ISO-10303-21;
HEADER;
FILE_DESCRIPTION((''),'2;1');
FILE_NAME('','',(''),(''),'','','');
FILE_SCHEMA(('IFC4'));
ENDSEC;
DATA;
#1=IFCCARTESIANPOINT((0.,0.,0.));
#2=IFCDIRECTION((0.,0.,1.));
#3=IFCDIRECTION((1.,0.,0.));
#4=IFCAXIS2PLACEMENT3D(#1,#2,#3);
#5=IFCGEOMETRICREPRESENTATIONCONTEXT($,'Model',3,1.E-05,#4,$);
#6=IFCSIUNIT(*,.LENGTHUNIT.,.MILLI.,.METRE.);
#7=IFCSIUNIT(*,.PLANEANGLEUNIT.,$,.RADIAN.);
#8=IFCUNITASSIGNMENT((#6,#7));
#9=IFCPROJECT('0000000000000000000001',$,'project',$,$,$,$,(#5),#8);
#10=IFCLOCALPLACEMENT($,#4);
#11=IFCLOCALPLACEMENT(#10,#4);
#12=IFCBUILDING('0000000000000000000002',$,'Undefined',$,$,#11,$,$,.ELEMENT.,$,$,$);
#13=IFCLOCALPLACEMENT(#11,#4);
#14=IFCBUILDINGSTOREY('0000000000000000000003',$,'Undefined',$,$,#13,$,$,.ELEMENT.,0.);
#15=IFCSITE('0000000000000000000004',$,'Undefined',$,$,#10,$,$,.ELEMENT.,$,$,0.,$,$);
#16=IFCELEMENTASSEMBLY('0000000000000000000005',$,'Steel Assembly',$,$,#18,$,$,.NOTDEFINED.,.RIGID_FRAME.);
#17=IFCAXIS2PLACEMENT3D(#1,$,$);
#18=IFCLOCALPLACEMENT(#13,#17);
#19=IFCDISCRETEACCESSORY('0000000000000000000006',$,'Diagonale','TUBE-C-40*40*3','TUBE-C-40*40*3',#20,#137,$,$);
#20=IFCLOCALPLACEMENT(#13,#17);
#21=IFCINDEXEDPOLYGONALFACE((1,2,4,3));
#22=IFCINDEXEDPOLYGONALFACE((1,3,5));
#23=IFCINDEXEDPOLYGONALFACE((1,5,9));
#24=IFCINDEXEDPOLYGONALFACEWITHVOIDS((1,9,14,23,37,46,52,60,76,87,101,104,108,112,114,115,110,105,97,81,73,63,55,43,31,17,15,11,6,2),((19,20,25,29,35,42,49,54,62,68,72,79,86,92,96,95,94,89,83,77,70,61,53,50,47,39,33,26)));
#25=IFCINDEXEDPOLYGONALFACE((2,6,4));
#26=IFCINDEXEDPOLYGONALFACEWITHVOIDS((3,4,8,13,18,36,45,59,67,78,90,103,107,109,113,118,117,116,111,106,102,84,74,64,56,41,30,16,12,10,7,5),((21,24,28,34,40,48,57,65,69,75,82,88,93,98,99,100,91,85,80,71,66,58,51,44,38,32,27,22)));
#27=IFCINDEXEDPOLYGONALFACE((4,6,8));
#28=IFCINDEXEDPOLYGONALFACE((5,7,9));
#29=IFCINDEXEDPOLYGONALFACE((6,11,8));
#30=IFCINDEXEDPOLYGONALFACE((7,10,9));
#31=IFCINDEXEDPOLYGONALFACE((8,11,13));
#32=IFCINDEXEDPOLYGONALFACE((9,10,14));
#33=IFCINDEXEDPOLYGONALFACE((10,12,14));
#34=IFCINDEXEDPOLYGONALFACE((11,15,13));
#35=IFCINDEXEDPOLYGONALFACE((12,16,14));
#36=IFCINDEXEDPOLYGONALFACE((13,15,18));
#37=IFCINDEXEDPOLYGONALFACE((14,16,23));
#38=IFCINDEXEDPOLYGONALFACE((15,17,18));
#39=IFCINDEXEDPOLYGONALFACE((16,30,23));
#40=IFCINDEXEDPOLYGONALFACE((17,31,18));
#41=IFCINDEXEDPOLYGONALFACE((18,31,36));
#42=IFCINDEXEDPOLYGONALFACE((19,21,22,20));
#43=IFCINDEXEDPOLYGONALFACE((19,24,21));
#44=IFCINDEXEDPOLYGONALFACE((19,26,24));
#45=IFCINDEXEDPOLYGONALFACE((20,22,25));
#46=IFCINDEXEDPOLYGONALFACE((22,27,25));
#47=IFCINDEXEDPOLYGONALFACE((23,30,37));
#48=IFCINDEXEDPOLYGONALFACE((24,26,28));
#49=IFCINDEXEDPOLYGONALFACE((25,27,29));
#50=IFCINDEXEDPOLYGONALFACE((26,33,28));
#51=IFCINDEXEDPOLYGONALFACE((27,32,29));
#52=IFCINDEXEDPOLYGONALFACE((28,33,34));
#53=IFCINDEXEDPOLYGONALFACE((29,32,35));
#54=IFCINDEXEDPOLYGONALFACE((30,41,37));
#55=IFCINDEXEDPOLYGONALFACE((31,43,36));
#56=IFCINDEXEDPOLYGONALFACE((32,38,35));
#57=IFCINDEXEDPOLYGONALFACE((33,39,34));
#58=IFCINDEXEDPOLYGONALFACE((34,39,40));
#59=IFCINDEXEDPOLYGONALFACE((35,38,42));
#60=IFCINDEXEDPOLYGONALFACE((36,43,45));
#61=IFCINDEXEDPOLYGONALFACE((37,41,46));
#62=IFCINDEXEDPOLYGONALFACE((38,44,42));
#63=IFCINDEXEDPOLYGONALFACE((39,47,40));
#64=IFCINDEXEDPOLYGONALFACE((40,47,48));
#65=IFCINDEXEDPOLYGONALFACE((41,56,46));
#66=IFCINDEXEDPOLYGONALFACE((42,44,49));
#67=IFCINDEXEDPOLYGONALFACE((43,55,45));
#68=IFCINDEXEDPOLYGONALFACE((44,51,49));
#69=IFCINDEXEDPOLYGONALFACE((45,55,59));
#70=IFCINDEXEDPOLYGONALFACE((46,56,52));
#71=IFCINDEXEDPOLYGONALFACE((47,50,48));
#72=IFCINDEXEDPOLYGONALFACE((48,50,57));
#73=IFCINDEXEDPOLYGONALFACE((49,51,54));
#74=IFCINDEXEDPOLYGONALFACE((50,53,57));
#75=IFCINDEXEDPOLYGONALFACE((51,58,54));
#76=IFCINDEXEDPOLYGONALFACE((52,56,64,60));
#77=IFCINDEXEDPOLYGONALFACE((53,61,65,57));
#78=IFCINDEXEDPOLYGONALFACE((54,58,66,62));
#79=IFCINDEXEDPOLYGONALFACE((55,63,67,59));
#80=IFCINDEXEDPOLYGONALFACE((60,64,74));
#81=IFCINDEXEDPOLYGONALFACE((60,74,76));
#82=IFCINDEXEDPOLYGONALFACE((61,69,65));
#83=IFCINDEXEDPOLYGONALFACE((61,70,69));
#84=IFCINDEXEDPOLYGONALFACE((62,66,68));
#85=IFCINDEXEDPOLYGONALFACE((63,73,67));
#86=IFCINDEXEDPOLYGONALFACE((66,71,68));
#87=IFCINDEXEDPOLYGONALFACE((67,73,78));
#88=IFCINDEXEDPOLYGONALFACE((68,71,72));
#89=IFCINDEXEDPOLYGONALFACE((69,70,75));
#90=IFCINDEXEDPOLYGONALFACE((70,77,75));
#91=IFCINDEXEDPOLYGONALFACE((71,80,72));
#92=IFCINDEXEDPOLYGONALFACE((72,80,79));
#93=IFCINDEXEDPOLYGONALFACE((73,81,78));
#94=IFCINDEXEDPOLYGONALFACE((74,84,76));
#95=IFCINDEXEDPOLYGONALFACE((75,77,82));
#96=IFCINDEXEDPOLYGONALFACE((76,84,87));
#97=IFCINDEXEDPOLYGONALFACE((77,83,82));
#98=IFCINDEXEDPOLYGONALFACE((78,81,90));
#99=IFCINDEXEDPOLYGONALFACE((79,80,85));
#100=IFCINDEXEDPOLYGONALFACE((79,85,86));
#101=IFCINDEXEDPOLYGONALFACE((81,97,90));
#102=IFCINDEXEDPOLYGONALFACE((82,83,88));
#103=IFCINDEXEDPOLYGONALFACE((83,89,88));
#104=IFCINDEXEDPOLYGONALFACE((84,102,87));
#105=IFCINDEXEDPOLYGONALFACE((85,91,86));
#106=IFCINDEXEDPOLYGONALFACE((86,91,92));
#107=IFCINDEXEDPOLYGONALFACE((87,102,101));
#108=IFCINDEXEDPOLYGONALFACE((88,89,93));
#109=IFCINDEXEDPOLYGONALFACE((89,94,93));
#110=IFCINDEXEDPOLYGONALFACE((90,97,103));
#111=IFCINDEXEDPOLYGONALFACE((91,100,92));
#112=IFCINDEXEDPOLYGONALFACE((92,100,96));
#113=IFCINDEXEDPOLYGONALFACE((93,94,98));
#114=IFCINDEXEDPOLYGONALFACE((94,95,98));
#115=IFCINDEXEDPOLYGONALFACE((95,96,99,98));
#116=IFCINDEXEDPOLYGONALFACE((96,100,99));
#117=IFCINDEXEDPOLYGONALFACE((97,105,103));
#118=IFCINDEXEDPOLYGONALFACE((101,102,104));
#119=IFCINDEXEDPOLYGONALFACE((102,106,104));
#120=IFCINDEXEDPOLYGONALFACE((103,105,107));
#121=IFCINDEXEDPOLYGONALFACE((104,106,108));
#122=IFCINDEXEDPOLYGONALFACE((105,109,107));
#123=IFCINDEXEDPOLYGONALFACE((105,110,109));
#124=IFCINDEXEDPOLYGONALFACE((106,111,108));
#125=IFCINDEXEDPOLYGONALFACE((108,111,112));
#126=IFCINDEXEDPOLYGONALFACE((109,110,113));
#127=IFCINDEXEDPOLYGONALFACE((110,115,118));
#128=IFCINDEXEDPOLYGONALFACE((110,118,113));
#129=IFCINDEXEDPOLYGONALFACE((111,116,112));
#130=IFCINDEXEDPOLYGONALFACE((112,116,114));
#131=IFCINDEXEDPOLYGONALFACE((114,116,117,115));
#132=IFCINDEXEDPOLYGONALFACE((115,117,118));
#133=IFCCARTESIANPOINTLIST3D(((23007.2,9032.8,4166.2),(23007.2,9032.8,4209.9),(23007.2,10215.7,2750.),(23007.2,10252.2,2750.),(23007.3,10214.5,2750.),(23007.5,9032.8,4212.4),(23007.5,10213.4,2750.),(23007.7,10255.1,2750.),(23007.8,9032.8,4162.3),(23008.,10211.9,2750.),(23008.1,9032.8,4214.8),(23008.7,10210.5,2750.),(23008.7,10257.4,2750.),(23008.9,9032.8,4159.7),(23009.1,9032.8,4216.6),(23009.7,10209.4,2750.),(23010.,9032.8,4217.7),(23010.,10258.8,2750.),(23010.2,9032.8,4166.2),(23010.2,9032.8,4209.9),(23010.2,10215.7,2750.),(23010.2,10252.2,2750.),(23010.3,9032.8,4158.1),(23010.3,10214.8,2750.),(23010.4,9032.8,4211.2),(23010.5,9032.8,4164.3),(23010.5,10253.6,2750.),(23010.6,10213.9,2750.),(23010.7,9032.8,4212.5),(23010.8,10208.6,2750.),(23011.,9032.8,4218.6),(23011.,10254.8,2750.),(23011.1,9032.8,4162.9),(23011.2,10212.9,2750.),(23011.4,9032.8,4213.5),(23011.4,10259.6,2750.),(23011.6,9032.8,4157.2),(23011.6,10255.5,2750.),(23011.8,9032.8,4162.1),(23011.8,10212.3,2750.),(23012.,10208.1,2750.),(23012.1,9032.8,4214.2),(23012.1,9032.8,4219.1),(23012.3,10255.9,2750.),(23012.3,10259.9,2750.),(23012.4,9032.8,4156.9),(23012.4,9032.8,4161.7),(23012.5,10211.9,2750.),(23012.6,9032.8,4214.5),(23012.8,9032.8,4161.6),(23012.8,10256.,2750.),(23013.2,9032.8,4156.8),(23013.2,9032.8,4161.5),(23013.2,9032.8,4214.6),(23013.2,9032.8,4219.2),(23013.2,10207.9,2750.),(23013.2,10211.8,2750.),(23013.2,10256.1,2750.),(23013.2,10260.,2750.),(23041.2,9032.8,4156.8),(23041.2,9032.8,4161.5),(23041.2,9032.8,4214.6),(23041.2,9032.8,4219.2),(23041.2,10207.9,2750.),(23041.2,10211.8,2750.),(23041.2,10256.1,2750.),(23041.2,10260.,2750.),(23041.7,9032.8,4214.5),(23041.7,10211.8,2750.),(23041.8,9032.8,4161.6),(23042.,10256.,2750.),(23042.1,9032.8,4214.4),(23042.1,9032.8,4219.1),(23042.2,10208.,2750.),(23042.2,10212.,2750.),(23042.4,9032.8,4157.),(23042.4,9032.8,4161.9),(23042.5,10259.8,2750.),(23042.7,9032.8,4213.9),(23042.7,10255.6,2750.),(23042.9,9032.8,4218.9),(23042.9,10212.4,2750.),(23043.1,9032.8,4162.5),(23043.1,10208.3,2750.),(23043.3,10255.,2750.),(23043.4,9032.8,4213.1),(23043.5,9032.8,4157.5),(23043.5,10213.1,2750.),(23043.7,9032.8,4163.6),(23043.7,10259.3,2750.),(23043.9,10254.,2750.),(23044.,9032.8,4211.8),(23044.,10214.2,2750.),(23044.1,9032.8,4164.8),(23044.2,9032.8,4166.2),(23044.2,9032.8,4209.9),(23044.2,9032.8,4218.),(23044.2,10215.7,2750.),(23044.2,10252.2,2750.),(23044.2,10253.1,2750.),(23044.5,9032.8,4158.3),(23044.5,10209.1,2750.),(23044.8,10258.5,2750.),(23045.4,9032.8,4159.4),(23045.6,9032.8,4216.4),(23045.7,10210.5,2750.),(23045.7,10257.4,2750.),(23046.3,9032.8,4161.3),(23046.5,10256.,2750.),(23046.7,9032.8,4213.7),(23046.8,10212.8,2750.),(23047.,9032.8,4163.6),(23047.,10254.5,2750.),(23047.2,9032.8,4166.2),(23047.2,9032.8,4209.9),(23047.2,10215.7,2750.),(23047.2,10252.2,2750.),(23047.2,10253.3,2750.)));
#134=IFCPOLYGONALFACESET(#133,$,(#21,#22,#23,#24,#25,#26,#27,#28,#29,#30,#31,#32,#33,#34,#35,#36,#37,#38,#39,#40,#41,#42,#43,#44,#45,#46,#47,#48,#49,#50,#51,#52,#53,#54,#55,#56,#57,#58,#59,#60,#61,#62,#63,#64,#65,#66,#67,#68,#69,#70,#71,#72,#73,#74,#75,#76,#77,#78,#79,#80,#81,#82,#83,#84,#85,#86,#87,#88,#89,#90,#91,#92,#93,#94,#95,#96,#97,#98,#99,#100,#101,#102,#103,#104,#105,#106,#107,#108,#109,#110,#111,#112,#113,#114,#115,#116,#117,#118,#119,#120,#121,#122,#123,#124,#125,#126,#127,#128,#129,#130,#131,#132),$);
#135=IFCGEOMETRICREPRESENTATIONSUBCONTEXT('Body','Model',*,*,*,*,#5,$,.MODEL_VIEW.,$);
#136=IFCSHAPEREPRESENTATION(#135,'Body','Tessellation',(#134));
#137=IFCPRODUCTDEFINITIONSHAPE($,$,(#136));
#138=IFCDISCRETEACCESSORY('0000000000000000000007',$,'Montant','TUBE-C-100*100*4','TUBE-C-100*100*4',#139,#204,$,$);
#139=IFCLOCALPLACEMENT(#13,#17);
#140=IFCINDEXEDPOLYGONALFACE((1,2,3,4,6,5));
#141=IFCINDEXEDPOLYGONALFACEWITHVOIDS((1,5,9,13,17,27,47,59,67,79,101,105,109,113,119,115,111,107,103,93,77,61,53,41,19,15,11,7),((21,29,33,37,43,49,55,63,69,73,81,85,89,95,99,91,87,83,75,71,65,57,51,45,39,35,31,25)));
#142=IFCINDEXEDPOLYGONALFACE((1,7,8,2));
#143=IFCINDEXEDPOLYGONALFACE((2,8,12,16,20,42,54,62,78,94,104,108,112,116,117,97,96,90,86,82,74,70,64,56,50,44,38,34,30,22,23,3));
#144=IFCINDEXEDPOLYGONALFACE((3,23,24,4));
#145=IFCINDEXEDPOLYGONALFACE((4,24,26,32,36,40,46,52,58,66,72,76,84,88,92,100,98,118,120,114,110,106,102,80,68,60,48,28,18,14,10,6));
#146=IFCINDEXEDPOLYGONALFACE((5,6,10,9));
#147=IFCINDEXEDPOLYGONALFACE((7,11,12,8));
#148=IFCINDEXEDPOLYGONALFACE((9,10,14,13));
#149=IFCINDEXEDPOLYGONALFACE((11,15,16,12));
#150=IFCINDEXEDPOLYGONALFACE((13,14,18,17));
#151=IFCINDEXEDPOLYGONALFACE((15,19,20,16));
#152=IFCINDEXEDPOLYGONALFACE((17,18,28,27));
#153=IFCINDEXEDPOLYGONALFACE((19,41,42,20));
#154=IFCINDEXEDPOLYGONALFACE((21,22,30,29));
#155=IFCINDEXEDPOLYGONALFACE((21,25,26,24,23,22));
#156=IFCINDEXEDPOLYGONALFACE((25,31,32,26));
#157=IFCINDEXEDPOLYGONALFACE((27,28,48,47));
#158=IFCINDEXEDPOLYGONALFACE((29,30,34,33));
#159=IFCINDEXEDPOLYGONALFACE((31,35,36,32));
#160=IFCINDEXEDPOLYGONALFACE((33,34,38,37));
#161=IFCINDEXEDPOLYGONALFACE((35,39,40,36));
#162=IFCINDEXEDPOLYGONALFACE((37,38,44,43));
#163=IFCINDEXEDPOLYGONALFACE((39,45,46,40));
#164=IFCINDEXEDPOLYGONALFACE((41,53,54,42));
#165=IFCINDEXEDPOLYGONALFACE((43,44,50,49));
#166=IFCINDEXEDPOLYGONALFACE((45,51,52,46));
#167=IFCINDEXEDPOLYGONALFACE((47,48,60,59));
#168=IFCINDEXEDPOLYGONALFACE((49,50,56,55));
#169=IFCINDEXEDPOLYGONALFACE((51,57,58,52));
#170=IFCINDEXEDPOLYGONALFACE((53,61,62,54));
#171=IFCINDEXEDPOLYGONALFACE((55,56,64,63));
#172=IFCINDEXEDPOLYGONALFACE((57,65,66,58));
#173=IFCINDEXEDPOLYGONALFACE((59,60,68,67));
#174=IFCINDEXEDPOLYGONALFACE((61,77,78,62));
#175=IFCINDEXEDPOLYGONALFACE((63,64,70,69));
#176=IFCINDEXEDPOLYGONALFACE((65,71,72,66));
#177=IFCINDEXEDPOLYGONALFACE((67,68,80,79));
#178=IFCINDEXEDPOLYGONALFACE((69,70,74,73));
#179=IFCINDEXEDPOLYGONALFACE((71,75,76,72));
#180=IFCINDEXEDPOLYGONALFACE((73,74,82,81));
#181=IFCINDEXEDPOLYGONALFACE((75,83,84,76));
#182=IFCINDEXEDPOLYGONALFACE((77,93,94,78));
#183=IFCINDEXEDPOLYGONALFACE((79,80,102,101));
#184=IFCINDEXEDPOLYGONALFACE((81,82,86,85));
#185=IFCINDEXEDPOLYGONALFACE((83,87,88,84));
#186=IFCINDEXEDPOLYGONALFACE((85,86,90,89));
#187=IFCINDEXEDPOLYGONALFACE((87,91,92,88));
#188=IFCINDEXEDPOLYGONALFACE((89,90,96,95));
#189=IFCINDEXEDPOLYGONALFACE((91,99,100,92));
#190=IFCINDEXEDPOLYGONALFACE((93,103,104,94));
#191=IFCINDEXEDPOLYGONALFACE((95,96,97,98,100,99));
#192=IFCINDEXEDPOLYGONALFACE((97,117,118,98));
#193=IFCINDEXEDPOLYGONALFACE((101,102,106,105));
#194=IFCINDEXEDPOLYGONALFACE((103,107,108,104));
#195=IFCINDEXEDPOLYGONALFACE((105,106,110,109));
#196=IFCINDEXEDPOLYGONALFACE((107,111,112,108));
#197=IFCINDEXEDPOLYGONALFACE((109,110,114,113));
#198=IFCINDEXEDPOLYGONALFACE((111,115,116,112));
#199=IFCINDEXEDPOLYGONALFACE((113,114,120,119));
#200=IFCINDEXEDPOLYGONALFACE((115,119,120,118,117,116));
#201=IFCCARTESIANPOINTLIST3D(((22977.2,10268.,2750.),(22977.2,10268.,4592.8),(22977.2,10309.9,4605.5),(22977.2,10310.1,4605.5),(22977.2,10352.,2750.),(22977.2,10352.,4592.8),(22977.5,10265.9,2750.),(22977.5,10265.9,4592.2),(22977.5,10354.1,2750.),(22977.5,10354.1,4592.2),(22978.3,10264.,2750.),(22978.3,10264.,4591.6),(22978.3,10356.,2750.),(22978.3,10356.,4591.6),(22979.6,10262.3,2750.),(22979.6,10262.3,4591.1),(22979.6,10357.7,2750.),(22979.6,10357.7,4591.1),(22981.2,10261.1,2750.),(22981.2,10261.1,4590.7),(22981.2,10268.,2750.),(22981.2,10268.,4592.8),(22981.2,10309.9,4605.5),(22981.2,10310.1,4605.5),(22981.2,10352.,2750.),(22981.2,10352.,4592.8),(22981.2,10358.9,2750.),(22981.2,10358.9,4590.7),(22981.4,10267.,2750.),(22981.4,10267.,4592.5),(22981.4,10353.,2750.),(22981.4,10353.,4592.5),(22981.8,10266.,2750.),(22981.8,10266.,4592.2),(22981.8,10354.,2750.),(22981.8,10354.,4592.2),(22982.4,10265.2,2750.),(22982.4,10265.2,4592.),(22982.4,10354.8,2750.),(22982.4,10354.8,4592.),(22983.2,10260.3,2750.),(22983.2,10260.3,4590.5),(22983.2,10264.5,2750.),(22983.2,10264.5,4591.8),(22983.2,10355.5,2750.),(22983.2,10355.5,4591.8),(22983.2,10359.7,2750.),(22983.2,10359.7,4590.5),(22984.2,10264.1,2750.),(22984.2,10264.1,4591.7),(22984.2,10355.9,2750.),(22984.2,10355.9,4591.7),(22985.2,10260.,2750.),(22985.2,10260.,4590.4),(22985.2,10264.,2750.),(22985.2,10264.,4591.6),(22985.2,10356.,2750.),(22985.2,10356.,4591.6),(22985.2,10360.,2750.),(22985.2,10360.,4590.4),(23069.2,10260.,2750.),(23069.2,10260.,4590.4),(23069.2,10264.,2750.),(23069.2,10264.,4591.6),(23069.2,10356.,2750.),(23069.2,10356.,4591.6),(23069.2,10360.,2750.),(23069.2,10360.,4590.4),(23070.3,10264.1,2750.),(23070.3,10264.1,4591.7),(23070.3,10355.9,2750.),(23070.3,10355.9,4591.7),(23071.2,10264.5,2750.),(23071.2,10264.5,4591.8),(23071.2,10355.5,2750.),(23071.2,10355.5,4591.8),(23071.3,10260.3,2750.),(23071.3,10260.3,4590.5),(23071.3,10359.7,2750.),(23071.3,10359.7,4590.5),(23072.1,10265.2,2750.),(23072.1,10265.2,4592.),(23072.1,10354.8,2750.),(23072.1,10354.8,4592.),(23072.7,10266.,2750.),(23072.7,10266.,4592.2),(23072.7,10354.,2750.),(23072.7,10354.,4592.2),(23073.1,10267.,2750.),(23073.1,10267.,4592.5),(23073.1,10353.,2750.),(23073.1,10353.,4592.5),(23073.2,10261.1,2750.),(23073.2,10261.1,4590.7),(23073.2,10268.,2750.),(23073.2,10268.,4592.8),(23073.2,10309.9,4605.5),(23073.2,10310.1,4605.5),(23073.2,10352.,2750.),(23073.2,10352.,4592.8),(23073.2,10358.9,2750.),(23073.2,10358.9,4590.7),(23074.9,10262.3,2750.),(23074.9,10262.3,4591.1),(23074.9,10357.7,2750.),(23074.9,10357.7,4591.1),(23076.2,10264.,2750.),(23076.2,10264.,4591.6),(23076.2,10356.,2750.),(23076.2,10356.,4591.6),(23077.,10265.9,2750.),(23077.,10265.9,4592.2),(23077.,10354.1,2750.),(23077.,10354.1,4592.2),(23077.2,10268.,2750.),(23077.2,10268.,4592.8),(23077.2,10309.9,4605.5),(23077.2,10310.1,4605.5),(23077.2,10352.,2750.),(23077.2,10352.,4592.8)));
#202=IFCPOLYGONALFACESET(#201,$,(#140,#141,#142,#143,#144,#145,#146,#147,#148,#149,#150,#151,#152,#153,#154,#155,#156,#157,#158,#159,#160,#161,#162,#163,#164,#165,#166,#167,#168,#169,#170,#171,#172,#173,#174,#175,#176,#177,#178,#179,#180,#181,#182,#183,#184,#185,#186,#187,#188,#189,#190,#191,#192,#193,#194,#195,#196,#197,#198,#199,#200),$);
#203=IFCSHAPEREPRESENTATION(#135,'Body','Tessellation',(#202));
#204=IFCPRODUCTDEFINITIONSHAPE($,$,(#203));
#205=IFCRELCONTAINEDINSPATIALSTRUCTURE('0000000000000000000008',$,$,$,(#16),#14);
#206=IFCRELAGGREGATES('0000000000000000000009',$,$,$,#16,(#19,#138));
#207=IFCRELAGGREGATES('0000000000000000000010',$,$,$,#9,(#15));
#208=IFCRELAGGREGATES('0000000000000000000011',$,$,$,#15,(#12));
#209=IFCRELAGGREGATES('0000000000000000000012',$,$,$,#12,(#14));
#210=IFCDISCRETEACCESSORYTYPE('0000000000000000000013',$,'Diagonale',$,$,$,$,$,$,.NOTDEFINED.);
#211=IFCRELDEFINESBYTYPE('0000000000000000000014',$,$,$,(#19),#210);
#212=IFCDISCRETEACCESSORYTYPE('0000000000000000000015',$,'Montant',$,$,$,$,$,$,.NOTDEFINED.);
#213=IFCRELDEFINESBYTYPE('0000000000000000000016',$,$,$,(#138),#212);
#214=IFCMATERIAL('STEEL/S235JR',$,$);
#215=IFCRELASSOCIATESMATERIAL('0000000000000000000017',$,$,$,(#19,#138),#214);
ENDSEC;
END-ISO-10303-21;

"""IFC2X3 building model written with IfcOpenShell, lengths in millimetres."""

from ifc_helpers import new_model, si_unit, frame, origin_with_axes, origin_2d_with_axis, place, context, subcontext, project, spatial, hollow_rectangle, extrude, clip, halfspace, material, type_object, element, aggregate, save


model = new_model("IFC2X3")

# Units and contexts
model_context = context("Model", 3, precision=1e-05, world=origin_with_axes())
body_context = subcontext(model_context, "Body", "Model", "MODEL_VIEW")
ifc_project = project(units=[si_unit("LENGTHUNIT", "METRE", prefix="MILLI"), si_unit("PLANEANGLEUNIT", "RADIAN")], contexts=[model_context])

# Site, building, storey
site_placement = place(None, origin_with_axes())
site = spatial("IfcSite", under=ifc_project, at=site_placement, Name="Undefined", CompositionType="ELEMENT", RefElevation=0.0)
building_placement = place(site_placement, origin_with_axes())
building = spatial("IfcBuilding", under=site, at=building_placement, Name="Undefined", CompositionType="ELEMENT")
storey_placement = place(building_placement, origin_with_axes())
storey = spatial("IfcBuildingStorey", under=building, at=storey_placement, Name="Undefined", CompositionType="ELEMENT", Elevation=0.0)

# Element assembly, discrete accessories
ifc_material_1 = material(Name="STEEL/S235JR")
assembly_1_placement = place(storey_placement, origin_with_axes())
assembly_1 = element("IfcElementAssembly", 1, at=assembly_1_placement, inside=storey, Name="Steel Assembly", AssemblyPlace="NOTDEFINED", PredefinedType="RIGID_FRAME")
discrete_accessory_type_1 = type_object("IfcDiscreteAccessoryType", Name="Diagonale")
discrete_accessory_1_placement = place(assembly_1_placement, frame((23027.2, 10244.6, 2737.2), z_axis=(0.0, 0.767483, 0.64107), x_axis=(0.0, -0.64107, 0.767483)))
discrete_accessory_1 = element("IfcDiscreteAccessory", 2, at=discrete_accessory_1_placement, type_object=discrete_accessory_type_1, material=ifc_material_1, Name="Diagonale", Description="TUBE-C-40*40*3", ObjectType="TUBE-C-40*40*3", context=body_context, shape_type="Clipping", body=[
    clip(clip(extrude(hollow_rectangle(XDim=40.0, YDim=40.0, WallThickness=3.0, InnerFilletRadius=3.0, OuterFilletRadius=6.0, at=origin_2d_with_axis()), frame((1931.5, 0.0, 0.0), z_axis=(-1.0, 0.0, 0.0), x_axis=(0.0, -1.0, 0.0)), (0.0, 0.0, 1.0), 1955.8), halfspace(frame((1843.1, 0.0, -39.5), z_axis=(0.64107, 0.0, -0.767483), x_axis=(0.767483, 0.0, 0.64107)), False)), halfspace(frame((17.2, 0.0, -0.6), z_axis=(-0.767483, 0.0, -0.64107), x_axis=(0.64107, 0.0, -0.767483)), False)),
])
discrete_accessory_type_2 = type_object("IfcDiscreteAccessoryType", Name="Montant")
discrete_accessory_2_placement = place(assembly_1_placement, frame((23027.2, 10310.0, 4605.5), z_axis=(-1.0, 0.0, 0.0), x_axis=(0.0, 0.0, -1.0)))
discrete_accessory_2 = element("IfcDiscreteAccessory", 3, at=discrete_accessory_2_placement, type_object=discrete_accessory_type_2, material=ifc_material_1, Name="Montant", Description="TUBE-C-100*100*4", ObjectType="TUBE-C-100*100*4", context=body_context, shape_type="Clipping", body=[
    clip(clip(extrude(hollow_rectangle(XDim=100.0, YDim=100.0, WallThickness=4.0, InnerFilletRadius=4.0, OuterFilletRadius=8.0, at=origin_2d_with_axis()), frame((1855.5, 0.0, 0.0), z_axis=(-1.0, 0.0, 0.0), x_axis=(0.0, -1.0, 0.0)), (0.0, 0.0, 1.0), 1855.5), halfspace(frame((-15.1, -50.0, -50.0), z_axis=(-0.957179, 0.289497, 0.0), x_axis=(0.289497, 0.957179, 0.0)), False)), halfspace(frame((-15.1, 50.0, -50.0), z_axis=(-0.957179, -0.289497, 0.0), x_axis=(0.0, 0.0, 1.0)), False)),
])
aggregate(assembly_1, [discrete_accessory_1, discrete_accessory_2])

save(model, "model.ifc")
